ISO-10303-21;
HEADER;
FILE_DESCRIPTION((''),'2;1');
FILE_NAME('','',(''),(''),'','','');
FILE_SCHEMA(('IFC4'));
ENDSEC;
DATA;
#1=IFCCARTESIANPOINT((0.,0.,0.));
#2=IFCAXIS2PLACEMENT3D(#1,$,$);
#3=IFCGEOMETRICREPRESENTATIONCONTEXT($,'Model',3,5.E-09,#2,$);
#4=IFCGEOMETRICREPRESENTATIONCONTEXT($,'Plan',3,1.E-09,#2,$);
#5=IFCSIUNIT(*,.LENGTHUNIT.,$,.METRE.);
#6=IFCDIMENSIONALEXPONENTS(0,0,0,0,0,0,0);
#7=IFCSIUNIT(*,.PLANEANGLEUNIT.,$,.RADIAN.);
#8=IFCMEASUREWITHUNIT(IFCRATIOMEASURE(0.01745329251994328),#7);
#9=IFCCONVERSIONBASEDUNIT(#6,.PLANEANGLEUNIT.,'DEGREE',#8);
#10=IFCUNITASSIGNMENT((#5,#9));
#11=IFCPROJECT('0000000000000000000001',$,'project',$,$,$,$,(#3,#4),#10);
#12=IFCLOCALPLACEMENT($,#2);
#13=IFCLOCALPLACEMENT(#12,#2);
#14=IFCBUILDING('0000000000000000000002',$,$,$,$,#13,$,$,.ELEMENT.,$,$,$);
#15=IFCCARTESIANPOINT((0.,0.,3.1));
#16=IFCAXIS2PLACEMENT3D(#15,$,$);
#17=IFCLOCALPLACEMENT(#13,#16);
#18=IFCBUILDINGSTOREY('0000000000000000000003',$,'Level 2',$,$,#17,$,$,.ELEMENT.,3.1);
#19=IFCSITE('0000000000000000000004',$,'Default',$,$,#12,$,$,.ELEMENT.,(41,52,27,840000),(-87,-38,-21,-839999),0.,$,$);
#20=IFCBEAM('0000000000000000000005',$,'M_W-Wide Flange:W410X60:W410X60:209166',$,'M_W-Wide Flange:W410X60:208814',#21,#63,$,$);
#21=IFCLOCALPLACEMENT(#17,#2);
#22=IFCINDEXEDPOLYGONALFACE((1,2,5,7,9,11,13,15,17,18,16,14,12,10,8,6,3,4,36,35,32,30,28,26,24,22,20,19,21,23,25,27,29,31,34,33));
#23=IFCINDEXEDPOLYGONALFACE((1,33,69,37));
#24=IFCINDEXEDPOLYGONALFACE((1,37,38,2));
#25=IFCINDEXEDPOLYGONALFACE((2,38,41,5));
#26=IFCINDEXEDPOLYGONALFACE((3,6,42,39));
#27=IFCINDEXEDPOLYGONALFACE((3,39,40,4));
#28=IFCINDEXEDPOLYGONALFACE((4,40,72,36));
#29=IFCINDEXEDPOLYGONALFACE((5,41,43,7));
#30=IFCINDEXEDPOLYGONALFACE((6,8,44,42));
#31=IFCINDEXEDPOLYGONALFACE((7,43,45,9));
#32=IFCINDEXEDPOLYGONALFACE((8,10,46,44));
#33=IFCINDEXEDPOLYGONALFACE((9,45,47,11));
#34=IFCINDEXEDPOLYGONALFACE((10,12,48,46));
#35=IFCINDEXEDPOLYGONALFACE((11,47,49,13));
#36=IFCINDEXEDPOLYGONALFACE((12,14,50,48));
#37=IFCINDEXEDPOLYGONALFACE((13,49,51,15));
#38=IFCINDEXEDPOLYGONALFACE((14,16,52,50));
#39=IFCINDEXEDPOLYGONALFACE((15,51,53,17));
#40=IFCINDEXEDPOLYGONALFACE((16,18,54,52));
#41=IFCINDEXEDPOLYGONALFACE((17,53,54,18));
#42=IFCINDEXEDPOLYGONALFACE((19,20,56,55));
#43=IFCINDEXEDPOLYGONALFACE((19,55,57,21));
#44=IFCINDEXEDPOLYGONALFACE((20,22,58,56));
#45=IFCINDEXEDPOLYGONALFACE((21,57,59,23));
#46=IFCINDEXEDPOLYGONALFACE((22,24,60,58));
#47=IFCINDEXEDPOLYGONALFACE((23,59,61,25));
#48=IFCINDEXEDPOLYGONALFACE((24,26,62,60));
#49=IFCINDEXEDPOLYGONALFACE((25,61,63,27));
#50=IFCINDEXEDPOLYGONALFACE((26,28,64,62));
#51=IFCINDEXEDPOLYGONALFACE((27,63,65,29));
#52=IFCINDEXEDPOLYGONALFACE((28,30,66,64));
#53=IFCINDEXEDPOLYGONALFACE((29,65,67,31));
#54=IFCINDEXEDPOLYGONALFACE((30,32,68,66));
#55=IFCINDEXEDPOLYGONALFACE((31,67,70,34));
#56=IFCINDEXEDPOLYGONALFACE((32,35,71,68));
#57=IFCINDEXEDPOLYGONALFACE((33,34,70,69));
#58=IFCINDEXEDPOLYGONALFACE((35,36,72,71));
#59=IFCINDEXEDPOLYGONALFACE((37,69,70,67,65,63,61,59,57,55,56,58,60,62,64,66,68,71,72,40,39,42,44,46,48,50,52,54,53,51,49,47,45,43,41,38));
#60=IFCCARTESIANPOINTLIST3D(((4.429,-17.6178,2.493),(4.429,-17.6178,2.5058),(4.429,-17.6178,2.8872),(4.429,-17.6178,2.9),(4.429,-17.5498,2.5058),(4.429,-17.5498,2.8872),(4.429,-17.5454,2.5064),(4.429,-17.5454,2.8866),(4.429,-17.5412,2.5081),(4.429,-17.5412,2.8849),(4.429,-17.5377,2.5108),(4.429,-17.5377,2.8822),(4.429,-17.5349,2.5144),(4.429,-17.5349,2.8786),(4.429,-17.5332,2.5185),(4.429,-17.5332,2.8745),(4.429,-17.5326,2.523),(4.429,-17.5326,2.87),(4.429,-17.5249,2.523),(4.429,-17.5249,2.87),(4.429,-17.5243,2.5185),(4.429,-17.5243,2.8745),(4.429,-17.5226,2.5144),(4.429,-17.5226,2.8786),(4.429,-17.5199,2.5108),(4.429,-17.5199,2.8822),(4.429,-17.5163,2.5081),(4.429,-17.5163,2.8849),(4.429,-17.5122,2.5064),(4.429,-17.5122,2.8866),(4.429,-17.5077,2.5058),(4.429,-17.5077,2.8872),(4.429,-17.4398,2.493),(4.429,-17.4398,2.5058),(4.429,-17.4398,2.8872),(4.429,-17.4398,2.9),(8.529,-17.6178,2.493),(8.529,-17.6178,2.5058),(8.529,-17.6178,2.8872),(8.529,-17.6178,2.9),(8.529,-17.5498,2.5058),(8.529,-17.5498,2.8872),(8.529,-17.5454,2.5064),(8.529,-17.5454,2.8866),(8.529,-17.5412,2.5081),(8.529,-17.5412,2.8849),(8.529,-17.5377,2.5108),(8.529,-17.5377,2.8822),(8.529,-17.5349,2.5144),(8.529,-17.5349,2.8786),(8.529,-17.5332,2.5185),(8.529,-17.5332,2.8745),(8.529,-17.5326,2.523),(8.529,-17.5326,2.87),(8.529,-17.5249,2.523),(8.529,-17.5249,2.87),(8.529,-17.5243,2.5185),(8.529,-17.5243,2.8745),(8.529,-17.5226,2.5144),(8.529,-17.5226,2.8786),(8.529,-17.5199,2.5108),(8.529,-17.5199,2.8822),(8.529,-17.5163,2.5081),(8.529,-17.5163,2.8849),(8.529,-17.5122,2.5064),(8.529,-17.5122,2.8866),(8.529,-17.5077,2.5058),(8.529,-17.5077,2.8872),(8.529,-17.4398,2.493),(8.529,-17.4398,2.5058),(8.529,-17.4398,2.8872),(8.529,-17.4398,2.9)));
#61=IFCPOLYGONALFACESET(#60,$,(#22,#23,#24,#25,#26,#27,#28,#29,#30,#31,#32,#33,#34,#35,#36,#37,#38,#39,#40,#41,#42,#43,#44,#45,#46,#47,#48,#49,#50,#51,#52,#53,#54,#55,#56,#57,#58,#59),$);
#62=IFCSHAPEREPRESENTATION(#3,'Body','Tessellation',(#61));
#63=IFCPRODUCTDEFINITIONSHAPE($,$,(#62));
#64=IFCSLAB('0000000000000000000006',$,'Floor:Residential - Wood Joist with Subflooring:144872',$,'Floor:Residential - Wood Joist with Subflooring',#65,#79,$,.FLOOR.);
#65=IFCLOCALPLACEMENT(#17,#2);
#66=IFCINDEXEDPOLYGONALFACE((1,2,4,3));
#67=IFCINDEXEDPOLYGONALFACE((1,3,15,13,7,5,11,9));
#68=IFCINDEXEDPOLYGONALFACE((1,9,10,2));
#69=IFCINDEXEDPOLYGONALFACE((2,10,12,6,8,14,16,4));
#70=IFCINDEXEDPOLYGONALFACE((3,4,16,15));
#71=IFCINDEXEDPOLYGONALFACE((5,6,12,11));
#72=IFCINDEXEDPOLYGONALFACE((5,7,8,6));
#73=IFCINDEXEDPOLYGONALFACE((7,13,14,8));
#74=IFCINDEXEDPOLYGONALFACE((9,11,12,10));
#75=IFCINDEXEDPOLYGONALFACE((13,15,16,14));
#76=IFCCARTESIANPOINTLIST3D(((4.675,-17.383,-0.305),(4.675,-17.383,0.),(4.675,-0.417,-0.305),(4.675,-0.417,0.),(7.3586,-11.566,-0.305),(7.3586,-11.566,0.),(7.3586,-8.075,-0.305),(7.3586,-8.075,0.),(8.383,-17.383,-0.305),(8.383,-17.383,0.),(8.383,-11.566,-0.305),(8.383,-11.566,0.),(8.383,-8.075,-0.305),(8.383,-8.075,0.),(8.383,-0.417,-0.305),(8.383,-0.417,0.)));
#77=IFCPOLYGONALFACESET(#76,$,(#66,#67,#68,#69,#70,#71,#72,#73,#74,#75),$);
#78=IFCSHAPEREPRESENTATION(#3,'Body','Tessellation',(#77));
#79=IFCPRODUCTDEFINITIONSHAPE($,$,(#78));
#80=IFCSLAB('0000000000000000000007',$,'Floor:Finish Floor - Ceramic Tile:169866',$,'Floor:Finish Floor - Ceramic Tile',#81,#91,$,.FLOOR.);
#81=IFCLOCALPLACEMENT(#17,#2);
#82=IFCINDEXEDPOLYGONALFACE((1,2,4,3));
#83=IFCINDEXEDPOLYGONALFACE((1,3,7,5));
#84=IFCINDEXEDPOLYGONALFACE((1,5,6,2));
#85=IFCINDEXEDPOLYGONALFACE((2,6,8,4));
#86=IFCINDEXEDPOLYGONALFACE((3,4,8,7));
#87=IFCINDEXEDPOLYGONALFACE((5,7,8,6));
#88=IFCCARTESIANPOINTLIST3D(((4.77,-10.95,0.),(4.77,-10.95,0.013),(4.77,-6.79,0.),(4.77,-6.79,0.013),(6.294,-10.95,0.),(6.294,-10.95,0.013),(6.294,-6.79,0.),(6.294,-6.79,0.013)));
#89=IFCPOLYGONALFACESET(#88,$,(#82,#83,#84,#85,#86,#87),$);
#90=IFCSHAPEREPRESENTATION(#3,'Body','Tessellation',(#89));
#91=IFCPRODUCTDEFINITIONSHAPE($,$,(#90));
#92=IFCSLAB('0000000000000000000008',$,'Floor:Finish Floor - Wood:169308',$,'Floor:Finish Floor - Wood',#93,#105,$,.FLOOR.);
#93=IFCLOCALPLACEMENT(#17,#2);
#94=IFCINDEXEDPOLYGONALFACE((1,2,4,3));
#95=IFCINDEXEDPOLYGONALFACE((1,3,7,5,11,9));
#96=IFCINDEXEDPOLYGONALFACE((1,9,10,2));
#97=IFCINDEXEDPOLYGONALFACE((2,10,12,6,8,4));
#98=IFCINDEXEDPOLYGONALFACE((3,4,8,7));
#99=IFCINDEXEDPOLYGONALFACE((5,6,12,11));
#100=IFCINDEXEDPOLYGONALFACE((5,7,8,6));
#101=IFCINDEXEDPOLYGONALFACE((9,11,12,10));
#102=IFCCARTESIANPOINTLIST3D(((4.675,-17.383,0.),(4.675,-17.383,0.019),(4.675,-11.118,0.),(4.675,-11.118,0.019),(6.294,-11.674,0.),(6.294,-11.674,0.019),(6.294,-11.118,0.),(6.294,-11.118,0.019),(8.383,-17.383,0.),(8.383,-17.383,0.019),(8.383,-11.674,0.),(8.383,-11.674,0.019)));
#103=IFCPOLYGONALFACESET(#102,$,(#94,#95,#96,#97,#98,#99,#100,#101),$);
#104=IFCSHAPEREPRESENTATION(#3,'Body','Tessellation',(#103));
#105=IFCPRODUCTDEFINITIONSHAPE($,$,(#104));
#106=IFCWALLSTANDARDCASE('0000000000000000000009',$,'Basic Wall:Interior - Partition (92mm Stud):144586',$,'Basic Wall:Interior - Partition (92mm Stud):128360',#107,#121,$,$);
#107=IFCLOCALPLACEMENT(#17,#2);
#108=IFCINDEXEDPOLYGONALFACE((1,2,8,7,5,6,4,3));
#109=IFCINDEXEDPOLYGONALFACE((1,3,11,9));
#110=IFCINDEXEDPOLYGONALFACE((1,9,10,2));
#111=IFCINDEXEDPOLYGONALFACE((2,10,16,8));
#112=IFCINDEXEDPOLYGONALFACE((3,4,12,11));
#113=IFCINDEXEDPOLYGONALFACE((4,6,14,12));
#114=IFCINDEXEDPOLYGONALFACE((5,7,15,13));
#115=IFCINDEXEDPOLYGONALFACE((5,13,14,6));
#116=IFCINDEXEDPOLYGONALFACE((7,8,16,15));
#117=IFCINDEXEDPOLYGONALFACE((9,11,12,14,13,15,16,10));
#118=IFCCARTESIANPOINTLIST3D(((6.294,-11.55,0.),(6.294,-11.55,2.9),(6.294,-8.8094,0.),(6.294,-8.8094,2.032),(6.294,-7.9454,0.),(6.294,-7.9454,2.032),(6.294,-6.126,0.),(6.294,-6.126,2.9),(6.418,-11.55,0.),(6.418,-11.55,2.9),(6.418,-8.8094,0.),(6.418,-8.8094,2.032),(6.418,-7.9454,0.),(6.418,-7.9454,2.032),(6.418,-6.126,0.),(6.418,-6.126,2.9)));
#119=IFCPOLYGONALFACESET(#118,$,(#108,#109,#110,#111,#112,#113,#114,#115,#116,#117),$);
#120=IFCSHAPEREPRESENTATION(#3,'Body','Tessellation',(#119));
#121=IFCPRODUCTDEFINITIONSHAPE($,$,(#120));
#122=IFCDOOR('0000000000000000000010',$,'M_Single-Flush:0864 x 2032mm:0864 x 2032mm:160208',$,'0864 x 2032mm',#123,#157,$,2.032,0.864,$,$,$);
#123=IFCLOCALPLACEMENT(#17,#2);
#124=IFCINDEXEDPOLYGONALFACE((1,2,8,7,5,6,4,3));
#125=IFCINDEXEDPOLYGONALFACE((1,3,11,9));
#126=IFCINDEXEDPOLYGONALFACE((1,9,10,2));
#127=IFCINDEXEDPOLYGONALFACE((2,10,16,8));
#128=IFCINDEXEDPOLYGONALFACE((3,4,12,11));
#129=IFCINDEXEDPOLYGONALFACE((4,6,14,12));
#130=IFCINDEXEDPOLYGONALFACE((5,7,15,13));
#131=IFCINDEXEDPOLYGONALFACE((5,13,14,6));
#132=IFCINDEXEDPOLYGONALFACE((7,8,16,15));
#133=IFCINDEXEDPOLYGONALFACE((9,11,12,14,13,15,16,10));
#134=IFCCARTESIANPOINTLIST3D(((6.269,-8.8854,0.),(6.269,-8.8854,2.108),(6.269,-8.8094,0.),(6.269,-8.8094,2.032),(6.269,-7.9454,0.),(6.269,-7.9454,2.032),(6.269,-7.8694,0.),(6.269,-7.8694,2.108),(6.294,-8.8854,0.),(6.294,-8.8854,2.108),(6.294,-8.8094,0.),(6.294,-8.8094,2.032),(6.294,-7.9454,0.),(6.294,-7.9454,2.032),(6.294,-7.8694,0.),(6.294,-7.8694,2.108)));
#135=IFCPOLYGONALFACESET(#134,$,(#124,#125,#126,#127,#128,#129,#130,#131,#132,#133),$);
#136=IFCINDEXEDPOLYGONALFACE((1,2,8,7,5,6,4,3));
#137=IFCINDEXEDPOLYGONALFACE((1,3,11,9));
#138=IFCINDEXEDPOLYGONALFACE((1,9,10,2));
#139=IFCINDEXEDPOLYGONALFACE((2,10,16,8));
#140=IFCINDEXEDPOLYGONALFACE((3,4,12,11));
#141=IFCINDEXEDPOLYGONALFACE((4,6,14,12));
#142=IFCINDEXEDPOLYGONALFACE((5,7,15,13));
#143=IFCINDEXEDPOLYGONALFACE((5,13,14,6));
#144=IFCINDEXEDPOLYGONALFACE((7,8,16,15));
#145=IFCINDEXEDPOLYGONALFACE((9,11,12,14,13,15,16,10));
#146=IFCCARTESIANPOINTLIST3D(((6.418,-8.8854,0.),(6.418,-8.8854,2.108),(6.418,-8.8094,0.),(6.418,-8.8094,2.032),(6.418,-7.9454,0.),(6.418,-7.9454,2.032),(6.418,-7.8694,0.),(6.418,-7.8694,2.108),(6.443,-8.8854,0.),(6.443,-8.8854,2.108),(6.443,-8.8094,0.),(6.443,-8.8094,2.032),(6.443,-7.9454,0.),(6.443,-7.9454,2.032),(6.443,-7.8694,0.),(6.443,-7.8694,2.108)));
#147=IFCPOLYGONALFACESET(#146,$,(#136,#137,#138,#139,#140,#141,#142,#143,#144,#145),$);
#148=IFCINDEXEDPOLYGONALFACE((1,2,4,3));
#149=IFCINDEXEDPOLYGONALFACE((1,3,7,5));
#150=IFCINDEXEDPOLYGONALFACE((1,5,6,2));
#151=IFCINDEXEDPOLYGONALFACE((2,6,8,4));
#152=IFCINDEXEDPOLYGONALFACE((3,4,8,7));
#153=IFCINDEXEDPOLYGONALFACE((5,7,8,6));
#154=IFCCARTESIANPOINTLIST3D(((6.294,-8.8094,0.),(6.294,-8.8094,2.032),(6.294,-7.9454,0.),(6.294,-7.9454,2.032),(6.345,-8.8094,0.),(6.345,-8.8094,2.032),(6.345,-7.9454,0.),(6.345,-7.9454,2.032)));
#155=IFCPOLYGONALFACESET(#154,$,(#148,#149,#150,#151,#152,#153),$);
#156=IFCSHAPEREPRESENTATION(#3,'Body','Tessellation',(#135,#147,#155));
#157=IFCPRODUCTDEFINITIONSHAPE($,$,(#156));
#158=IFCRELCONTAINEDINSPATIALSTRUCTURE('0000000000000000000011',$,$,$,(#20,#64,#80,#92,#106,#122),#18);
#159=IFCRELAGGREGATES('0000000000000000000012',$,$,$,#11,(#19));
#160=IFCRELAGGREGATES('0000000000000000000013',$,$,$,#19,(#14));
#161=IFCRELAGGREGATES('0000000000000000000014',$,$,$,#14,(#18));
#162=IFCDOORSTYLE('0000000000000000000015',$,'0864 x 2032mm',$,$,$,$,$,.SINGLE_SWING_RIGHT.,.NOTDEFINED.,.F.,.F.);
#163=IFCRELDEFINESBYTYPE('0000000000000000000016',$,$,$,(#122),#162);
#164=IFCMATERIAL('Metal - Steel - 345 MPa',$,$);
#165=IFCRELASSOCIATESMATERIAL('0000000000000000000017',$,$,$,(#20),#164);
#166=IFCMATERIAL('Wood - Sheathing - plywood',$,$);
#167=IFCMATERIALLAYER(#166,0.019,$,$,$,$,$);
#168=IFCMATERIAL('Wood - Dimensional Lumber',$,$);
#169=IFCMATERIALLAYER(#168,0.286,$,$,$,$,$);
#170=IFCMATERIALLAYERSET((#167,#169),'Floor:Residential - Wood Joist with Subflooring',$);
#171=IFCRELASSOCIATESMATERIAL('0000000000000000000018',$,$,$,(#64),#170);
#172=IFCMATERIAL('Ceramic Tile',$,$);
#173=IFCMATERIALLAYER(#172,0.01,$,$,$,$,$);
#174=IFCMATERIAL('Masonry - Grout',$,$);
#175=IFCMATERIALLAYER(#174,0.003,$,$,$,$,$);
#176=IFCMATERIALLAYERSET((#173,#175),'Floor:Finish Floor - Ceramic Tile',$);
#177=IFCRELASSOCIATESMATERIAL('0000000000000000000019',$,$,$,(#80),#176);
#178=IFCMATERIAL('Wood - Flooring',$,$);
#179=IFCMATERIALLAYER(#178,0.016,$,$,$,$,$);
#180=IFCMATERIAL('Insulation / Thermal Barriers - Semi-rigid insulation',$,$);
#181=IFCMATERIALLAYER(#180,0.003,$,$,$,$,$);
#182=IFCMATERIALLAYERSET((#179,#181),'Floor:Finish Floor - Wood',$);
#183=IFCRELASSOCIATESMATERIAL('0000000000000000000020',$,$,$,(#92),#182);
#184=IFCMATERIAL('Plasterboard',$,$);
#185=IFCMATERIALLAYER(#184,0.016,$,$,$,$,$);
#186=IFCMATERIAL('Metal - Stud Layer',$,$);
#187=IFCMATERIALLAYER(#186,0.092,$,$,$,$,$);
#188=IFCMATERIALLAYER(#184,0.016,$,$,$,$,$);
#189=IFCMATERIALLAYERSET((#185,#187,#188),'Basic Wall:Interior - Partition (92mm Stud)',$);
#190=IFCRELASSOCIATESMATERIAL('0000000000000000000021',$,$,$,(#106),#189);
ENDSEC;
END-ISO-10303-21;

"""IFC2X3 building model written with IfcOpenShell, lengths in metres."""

from ifc_helpers import new_model, entity, si_unit, converted_unit, frame, frame_2d, origin, origin_2d_with_axis, place, context, project, spatial, polyline, circle_curve, parameter, trimmed, segment, composite_curve, rectangle, outline, extrude, source, transform, mapped, material, layer, layer_set, layer_usage, type_object, type_shapes, element, fill, save


model = new_model("IFC2X3")

# Units and contexts
model_context = context("Model", 3, precision=5e-09, world=origin())
plan_context = context("Plan", 3, precision=1e-09, world=origin())
ifc_project = project(units=[si_unit("LENGTHUNIT", "METRE"), converted_unit("PLANEANGLEUNIT", "DEGREE", entity("IfcRatioMeasure", 0.01745329251994328), si_unit("PLANEANGLEUNIT", "RADIAN"), dimensions=[0, 0, 0, 0, 0, 0, 0])], contexts=[model_context, plan_context])

# Site, building, storey
site_placement = place(None, origin())
site = spatial("IfcSite", under=ifc_project, at=site_placement, Name="Default", CompositionType="ELEMENT", RefLatitude=(41, 52, 27, 840000), RefLongitude=(-87, -38, -21, -839999), RefElevation=0.0)
building_placement = place(site_placement, origin())
building = spatial("IfcBuilding", under=site, at=building_placement, CompositionType="ELEMENT")
storey_placement = place(building_placement, frame((0.0, 0.0, 3.1)))
storey = spatial("IfcBuildingStorey", under=building, at=storey_placement, Name="Level 2", CompositionType="ELEMENT", Elevation=3.1)

# Beam
ifc_material_1 = material(Name="Metal - Steel - 345 MPa")
beam_placement = place(storey_placement, frame((4.429, -17.5288, 2.9), z_axis=(0.0, 0.0, 1.0), x_axis=(0.0, -1.0, 0.0)))
element("IfcBeam", 1, at=beam_placement, inside=storey, material=ifc_material_1, Name="M_W-Wide Flange:W410X60:W410X60:209166", ObjectType="M_W-Wide Flange:W410X60:208814", context=model_context, shape_type="SweptSolid", body=[
    extrude(outline(composite_curve([segment(polyline([(-0.089, -0.1907), (-0.089, -0.2035)]), True, "CONTINUOUS"), segment(polyline([(-0.089, -0.2035), (0.089, -0.2035)]), True, "CONTINUOUS"), segment(polyline([(0.089, -0.2035), (0.089, -0.1907)]), True, "CONTINUOUS"), segment(polyline([(0.089, -0.1907), (0.021, -0.1907)]), True, "CONTINUOUS"), segment(trimmed(circle_curve(frame_2d((0.021, -0.1735), x_axis=(0.0, -1.0)), 0.0172), [parameter(270.0)], [parameter(360.0)], True, "PARAMETER"), False, "CONTINUOUS"), segment(polyline([(0.0038, -0.1735), (0.0038, 0.1735)]), True, "CONTINUOUS"), segment(trimmed(circle_curve(frame_2d((0.021, 0.1735), x_axis=(-1.0, 0.0)), 0.0172), [parameter(270.0)], [parameter(360.0)], True, "PARAMETER"), False, "CONTINUOUS"), segment(polyline([(0.021, 0.1907), (0.089, 0.1907)]), True, "CONTINUOUS"), segment(polyline([(0.089, 0.1907), (0.089, 0.2035)]), True, "CONTINUOUS"), segment(polyline([(0.089, 0.2035), (-0.089, 0.2035)]), True, "CONTINUOUS"), segment(polyline([(-0.089, 0.2035), (-0.089, 0.1907)]), True, "CONTINUOUS"), segment(polyline([(-0.089, 0.1907), (-0.0211, 0.1907)]), True, "CONTINUOUS"), segment(trimmed(circle_curve(frame_2d((-0.0211, 0.1735), x_axis=(0.0, 1.0)), 0.0172), [parameter(270.0)], [parameter(0.0)], True, "PARAMETER"), False, "CONTINUOUS"), segment(polyline([(-0.0039, 0.1735), (-0.0039, -0.1735)]), True, "CONTINUOUS"), segment(trimmed(circle_curve(frame_2d((-0.0211, -0.1735), x_axis=(1.0, 0.0)), 0.0172), [parameter(270.0)], [parameter(0.0)], True, "PARAMETER"), False, "CONTINUOUS"), segment(polyline([(-0.0211, -0.1907), (-0.089, -0.1907)]), True, "CONTINUOUS")], self_intersect=False)), frame((0.0, 0.0, -0.2035), z_axis=(0.0, -1.0, 0.0), x_axis=(1.0, 0.0, 0.0)), (0.0, 0.0, -1.0), 4.1),
])

# Slabs
ifc_material_2 = material(Name="Wood - Sheathing - plywood")
ifc_layer_1 = layer(ifc_material_2, 0.019)
ifc_material_3 = material(Name="Wood - Dimensional Lumber")
ifc_layer_2 = layer(ifc_material_3, 0.286)
ifc_layer_set_1 = layer_set([ifc_layer_1, ifc_layer_2], Name="Floor:Residential - Wood Joist with Subflooring")
ifc_layer_usage_1 = layer_usage(ifc_layer_set_1, "AXIS3", "POSITIVE", 0.0)
slab_1_placement = place(storey_placement, frame((4.675, -17.383, -0.305)))
element("IfcSlab", 2, at=slab_1_placement, inside=storey, material=ifc_layer_usage_1, Name="Floor:Residential - Wood Joist with Subflooring:144872", ObjectType="Floor:Residential - Wood Joist with Subflooring", PredefinedType="FLOOR", context=model_context, shape_type="SweptSolid", body=[
    extrude(outline(polyline([(-1.854, 8.483), (-1.854, 0.825), (-0.8296, 0.825), (-0.8296, -2.666), (-1.854, -2.666), (-1.854, -8.483), (1.854, -8.483), (1.854, 8.483), (-1.854, 8.483)])), frame((1.854, 8.483, 0.305), z_axis=(0.0, 0.0, -1.0), x_axis=(-1.0, 0.0, 0.0)), (0.0, 0.0, 1.0), 0.305),
])
ifc_material_4 = material(Name="Ceramic Tile")
ifc_layer_3 = layer(ifc_material_4, 0.01)
ifc_material_5 = material(Name="Masonry - Grout")
ifc_layer_4 = layer(ifc_material_5, 0.003)
ifc_layer_set_2 = layer_set([ifc_layer_3, ifc_layer_4], Name="Floor:Finish Floor - Ceramic Tile")
ifc_layer_usage_2 = layer_usage(ifc_layer_set_2, "AXIS3", "POSITIVE", 0.0)
slab_2_placement = place(storey_placement, frame((4.77, -10.95, 0.0)))
element("IfcSlab", 3, at=slab_2_placement, inside=storey, material=ifc_layer_usage_2, Name="Floor:Finish Floor - Ceramic Tile:169866", ObjectType="Floor:Finish Floor - Ceramic Tile", PredefinedType="FLOOR", context=model_context, shape_type="SweptSolid", body=[
    extrude(rectangle(XDim=4.16, YDim=1.524, at=frame_2d((0.0, 0.0), x_axis=(0.0, -1.0))), frame((0.762, 2.08, 0.013), z_axis=(0.0, 0.0, -1.0), x_axis=(-1.0, 0.0, 0.0)), (0.0, 0.0, 1.0), 0.013),
])
ifc_material_6 = material(Name="Wood - Flooring")
ifc_layer_5 = layer(ifc_material_6, 0.016)
ifc_material_7 = material(Name="Insulation / Thermal Barriers - Semi-rigid insulation")
ifc_layer_6 = layer(ifc_material_7, 0.003)
ifc_layer_set_3 = layer_set([ifc_layer_5, ifc_layer_6], Name="Floor:Finish Floor - Wood")
ifc_layer_usage_3 = layer_usage(ifc_layer_set_3, "AXIS3", "POSITIVE", 0.0)
slab_3_placement = place(storey_placement, frame((4.675, -17.383, 0.0)))
element("IfcSlab", 4, at=slab_3_placement, inside=storey, material=ifc_layer_usage_3, Name="Floor:Finish Floor - Wood:169308", ObjectType="Floor:Finish Floor - Wood", PredefinedType="FLOOR", context=model_context, shape_type="SweptSolid", body=[
    extrude(outline(polyline([(-1.854, 2.5765), (-1.854, -3.1325), (1.854, -3.1325), (1.854, 3.1325), (0.235, 3.1325), (0.235, 2.5765), (-1.854, 2.5765)])), frame((1.854, 3.1325, 0.019), z_axis=(0.0, 0.0, -1.0), x_axis=(-1.0, 0.0, 0.0)), (0.0, 0.0, 1.0), 0.019),
])

# Wall, opening, door
ifc_material_8 = material(Name="Plasterboard")
ifc_layer_7 = layer(ifc_material_8, 0.016)
ifc_material_9 = material(Name="Metal - Stud Layer")
ifc_layer_8 = layer(ifc_material_9, 0.092)
ifc_layer_9 = layer(ifc_material_8, 0.016)
ifc_layer_set_4 = layer_set([ifc_layer_7, ifc_layer_8, ifc_layer_9], Name="Basic Wall:Interior - Partition (92mm Stud)")
ifc_layer_usage_4 = layer_usage(ifc_layer_set_4, "AXIS2", "NEGATIVE", 0.062)
wall_1_placement = place(storey_placement, frame((6.356, -11.55, 0.0), z_axis=(0.0, 0.0, 1.0), x_axis=(0.0, 1.0, 0.0)))
wall_1 = element("IfcWallStandardCase", 5, at=wall_1_placement, inside=storey, material=ifc_layer_usage_4, Name="Basic Wall:Interior - Partition (92mm Stud):144586", ObjectType="Basic Wall:Interior - Partition (92mm Stud):128360", context=model_context, shape_type="SweptSolid", body=[
    extrude(rectangle(XDim=5.424, YDim=0.124, at=frame_2d((2.712, 0.0), x_axis=(-1.0, 0.0))), origin(), (0.0, 0.0, 1.0), 2.9),
])
opening_1_placement = place(wall_1_placement, frame((2.7406, -0.062, 0.0)))
opening_1 = element("IfcOpeningElement", 6, at=opening_1_placement, cuts=wall_1, ObjectType="Opening", context=model_context, shape_type="SweptSolid", body=[
    extrude(rectangle(XDim=0.864, YDim=2.032, at=frame_2d((1.016, 0.432), x_axis=(0.0, 1.0))), frame((0.0, 0.0, 0.0), z_axis=(0.0, 1.0, 0.0), x_axis=(0.0, 0.0, 1.0)), (0.0, 0.0, 1.0), 0.124),
])
door_style = type_object("IfcDoorStyle", Name="0864 x 2032mm", ConstructionType="NOTDEFINED", OperationType="SINGLE_SWING_RIGHT", ParameterTakesPrecedence=False, Sizeable=False)
shared_shape_1 = source(origin(), model_context, "Body", "SweptSolid", [
    extrude(outline(polyline([(-0.508, -1.073), (0.508, -1.073), (0.508, 1.035), (0.432, 1.035), (0.432, -0.997), (-0.432, -0.997), (-0.432, 1.035), (-0.508, 1.035), (-0.508, -1.073)])), frame((0.432, 0.124, 1.035), z_axis=(0.0, 1.0, 0.0), x_axis=(1.0, 0.0, 0.0)), (0.0, 0.0, 1.0), 0.025),
    extrude(outline(polyline([(-1.073, -0.508), (1.035, -0.508), (1.035, -0.432), (-0.997, -0.432), (-0.997, 0.432), (1.035, 0.432), (1.035, 0.508), (-1.073, 0.508), (-1.073, -0.508)])), frame((0.432, -0.025, 1.035), z_axis=(0.0, 1.0, 0.0), x_axis=(0.0, 0.0, -1.0)), (0.0, 0.0, 1.0), 0.025),
    extrude(rectangle(XDim=0.051, YDim=0.864, at=origin_2d_with_axis()), frame((0.432, 0.0985, 0.0), z_axis=(0.0, 0.0, 1.0), x_axis=(0.0, 1.0, 0.0)), (0.0, 0.0, 1.0), 2.032),
])
type_shapes(door_style, [shared_shape_1])
door_placement = place(opening_1_placement, origin())
door = element("IfcDoor", 7, at=door_placement, inside=storey, type_object=door_style, Name="M_Single-Flush:0864 x 2032mm:0864 x 2032mm:160208", ObjectType="0864 x 2032mm", OverallHeight=2.032, OverallWidth=0.864, context=model_context, shape_type="MappedRepresentation", body=[
    mapped(shared_shape_1, transform((0.0, 0.0, 0.0), scale=1.0)),
])
fill(opening_1, door)

save(model, "model.ifc")
